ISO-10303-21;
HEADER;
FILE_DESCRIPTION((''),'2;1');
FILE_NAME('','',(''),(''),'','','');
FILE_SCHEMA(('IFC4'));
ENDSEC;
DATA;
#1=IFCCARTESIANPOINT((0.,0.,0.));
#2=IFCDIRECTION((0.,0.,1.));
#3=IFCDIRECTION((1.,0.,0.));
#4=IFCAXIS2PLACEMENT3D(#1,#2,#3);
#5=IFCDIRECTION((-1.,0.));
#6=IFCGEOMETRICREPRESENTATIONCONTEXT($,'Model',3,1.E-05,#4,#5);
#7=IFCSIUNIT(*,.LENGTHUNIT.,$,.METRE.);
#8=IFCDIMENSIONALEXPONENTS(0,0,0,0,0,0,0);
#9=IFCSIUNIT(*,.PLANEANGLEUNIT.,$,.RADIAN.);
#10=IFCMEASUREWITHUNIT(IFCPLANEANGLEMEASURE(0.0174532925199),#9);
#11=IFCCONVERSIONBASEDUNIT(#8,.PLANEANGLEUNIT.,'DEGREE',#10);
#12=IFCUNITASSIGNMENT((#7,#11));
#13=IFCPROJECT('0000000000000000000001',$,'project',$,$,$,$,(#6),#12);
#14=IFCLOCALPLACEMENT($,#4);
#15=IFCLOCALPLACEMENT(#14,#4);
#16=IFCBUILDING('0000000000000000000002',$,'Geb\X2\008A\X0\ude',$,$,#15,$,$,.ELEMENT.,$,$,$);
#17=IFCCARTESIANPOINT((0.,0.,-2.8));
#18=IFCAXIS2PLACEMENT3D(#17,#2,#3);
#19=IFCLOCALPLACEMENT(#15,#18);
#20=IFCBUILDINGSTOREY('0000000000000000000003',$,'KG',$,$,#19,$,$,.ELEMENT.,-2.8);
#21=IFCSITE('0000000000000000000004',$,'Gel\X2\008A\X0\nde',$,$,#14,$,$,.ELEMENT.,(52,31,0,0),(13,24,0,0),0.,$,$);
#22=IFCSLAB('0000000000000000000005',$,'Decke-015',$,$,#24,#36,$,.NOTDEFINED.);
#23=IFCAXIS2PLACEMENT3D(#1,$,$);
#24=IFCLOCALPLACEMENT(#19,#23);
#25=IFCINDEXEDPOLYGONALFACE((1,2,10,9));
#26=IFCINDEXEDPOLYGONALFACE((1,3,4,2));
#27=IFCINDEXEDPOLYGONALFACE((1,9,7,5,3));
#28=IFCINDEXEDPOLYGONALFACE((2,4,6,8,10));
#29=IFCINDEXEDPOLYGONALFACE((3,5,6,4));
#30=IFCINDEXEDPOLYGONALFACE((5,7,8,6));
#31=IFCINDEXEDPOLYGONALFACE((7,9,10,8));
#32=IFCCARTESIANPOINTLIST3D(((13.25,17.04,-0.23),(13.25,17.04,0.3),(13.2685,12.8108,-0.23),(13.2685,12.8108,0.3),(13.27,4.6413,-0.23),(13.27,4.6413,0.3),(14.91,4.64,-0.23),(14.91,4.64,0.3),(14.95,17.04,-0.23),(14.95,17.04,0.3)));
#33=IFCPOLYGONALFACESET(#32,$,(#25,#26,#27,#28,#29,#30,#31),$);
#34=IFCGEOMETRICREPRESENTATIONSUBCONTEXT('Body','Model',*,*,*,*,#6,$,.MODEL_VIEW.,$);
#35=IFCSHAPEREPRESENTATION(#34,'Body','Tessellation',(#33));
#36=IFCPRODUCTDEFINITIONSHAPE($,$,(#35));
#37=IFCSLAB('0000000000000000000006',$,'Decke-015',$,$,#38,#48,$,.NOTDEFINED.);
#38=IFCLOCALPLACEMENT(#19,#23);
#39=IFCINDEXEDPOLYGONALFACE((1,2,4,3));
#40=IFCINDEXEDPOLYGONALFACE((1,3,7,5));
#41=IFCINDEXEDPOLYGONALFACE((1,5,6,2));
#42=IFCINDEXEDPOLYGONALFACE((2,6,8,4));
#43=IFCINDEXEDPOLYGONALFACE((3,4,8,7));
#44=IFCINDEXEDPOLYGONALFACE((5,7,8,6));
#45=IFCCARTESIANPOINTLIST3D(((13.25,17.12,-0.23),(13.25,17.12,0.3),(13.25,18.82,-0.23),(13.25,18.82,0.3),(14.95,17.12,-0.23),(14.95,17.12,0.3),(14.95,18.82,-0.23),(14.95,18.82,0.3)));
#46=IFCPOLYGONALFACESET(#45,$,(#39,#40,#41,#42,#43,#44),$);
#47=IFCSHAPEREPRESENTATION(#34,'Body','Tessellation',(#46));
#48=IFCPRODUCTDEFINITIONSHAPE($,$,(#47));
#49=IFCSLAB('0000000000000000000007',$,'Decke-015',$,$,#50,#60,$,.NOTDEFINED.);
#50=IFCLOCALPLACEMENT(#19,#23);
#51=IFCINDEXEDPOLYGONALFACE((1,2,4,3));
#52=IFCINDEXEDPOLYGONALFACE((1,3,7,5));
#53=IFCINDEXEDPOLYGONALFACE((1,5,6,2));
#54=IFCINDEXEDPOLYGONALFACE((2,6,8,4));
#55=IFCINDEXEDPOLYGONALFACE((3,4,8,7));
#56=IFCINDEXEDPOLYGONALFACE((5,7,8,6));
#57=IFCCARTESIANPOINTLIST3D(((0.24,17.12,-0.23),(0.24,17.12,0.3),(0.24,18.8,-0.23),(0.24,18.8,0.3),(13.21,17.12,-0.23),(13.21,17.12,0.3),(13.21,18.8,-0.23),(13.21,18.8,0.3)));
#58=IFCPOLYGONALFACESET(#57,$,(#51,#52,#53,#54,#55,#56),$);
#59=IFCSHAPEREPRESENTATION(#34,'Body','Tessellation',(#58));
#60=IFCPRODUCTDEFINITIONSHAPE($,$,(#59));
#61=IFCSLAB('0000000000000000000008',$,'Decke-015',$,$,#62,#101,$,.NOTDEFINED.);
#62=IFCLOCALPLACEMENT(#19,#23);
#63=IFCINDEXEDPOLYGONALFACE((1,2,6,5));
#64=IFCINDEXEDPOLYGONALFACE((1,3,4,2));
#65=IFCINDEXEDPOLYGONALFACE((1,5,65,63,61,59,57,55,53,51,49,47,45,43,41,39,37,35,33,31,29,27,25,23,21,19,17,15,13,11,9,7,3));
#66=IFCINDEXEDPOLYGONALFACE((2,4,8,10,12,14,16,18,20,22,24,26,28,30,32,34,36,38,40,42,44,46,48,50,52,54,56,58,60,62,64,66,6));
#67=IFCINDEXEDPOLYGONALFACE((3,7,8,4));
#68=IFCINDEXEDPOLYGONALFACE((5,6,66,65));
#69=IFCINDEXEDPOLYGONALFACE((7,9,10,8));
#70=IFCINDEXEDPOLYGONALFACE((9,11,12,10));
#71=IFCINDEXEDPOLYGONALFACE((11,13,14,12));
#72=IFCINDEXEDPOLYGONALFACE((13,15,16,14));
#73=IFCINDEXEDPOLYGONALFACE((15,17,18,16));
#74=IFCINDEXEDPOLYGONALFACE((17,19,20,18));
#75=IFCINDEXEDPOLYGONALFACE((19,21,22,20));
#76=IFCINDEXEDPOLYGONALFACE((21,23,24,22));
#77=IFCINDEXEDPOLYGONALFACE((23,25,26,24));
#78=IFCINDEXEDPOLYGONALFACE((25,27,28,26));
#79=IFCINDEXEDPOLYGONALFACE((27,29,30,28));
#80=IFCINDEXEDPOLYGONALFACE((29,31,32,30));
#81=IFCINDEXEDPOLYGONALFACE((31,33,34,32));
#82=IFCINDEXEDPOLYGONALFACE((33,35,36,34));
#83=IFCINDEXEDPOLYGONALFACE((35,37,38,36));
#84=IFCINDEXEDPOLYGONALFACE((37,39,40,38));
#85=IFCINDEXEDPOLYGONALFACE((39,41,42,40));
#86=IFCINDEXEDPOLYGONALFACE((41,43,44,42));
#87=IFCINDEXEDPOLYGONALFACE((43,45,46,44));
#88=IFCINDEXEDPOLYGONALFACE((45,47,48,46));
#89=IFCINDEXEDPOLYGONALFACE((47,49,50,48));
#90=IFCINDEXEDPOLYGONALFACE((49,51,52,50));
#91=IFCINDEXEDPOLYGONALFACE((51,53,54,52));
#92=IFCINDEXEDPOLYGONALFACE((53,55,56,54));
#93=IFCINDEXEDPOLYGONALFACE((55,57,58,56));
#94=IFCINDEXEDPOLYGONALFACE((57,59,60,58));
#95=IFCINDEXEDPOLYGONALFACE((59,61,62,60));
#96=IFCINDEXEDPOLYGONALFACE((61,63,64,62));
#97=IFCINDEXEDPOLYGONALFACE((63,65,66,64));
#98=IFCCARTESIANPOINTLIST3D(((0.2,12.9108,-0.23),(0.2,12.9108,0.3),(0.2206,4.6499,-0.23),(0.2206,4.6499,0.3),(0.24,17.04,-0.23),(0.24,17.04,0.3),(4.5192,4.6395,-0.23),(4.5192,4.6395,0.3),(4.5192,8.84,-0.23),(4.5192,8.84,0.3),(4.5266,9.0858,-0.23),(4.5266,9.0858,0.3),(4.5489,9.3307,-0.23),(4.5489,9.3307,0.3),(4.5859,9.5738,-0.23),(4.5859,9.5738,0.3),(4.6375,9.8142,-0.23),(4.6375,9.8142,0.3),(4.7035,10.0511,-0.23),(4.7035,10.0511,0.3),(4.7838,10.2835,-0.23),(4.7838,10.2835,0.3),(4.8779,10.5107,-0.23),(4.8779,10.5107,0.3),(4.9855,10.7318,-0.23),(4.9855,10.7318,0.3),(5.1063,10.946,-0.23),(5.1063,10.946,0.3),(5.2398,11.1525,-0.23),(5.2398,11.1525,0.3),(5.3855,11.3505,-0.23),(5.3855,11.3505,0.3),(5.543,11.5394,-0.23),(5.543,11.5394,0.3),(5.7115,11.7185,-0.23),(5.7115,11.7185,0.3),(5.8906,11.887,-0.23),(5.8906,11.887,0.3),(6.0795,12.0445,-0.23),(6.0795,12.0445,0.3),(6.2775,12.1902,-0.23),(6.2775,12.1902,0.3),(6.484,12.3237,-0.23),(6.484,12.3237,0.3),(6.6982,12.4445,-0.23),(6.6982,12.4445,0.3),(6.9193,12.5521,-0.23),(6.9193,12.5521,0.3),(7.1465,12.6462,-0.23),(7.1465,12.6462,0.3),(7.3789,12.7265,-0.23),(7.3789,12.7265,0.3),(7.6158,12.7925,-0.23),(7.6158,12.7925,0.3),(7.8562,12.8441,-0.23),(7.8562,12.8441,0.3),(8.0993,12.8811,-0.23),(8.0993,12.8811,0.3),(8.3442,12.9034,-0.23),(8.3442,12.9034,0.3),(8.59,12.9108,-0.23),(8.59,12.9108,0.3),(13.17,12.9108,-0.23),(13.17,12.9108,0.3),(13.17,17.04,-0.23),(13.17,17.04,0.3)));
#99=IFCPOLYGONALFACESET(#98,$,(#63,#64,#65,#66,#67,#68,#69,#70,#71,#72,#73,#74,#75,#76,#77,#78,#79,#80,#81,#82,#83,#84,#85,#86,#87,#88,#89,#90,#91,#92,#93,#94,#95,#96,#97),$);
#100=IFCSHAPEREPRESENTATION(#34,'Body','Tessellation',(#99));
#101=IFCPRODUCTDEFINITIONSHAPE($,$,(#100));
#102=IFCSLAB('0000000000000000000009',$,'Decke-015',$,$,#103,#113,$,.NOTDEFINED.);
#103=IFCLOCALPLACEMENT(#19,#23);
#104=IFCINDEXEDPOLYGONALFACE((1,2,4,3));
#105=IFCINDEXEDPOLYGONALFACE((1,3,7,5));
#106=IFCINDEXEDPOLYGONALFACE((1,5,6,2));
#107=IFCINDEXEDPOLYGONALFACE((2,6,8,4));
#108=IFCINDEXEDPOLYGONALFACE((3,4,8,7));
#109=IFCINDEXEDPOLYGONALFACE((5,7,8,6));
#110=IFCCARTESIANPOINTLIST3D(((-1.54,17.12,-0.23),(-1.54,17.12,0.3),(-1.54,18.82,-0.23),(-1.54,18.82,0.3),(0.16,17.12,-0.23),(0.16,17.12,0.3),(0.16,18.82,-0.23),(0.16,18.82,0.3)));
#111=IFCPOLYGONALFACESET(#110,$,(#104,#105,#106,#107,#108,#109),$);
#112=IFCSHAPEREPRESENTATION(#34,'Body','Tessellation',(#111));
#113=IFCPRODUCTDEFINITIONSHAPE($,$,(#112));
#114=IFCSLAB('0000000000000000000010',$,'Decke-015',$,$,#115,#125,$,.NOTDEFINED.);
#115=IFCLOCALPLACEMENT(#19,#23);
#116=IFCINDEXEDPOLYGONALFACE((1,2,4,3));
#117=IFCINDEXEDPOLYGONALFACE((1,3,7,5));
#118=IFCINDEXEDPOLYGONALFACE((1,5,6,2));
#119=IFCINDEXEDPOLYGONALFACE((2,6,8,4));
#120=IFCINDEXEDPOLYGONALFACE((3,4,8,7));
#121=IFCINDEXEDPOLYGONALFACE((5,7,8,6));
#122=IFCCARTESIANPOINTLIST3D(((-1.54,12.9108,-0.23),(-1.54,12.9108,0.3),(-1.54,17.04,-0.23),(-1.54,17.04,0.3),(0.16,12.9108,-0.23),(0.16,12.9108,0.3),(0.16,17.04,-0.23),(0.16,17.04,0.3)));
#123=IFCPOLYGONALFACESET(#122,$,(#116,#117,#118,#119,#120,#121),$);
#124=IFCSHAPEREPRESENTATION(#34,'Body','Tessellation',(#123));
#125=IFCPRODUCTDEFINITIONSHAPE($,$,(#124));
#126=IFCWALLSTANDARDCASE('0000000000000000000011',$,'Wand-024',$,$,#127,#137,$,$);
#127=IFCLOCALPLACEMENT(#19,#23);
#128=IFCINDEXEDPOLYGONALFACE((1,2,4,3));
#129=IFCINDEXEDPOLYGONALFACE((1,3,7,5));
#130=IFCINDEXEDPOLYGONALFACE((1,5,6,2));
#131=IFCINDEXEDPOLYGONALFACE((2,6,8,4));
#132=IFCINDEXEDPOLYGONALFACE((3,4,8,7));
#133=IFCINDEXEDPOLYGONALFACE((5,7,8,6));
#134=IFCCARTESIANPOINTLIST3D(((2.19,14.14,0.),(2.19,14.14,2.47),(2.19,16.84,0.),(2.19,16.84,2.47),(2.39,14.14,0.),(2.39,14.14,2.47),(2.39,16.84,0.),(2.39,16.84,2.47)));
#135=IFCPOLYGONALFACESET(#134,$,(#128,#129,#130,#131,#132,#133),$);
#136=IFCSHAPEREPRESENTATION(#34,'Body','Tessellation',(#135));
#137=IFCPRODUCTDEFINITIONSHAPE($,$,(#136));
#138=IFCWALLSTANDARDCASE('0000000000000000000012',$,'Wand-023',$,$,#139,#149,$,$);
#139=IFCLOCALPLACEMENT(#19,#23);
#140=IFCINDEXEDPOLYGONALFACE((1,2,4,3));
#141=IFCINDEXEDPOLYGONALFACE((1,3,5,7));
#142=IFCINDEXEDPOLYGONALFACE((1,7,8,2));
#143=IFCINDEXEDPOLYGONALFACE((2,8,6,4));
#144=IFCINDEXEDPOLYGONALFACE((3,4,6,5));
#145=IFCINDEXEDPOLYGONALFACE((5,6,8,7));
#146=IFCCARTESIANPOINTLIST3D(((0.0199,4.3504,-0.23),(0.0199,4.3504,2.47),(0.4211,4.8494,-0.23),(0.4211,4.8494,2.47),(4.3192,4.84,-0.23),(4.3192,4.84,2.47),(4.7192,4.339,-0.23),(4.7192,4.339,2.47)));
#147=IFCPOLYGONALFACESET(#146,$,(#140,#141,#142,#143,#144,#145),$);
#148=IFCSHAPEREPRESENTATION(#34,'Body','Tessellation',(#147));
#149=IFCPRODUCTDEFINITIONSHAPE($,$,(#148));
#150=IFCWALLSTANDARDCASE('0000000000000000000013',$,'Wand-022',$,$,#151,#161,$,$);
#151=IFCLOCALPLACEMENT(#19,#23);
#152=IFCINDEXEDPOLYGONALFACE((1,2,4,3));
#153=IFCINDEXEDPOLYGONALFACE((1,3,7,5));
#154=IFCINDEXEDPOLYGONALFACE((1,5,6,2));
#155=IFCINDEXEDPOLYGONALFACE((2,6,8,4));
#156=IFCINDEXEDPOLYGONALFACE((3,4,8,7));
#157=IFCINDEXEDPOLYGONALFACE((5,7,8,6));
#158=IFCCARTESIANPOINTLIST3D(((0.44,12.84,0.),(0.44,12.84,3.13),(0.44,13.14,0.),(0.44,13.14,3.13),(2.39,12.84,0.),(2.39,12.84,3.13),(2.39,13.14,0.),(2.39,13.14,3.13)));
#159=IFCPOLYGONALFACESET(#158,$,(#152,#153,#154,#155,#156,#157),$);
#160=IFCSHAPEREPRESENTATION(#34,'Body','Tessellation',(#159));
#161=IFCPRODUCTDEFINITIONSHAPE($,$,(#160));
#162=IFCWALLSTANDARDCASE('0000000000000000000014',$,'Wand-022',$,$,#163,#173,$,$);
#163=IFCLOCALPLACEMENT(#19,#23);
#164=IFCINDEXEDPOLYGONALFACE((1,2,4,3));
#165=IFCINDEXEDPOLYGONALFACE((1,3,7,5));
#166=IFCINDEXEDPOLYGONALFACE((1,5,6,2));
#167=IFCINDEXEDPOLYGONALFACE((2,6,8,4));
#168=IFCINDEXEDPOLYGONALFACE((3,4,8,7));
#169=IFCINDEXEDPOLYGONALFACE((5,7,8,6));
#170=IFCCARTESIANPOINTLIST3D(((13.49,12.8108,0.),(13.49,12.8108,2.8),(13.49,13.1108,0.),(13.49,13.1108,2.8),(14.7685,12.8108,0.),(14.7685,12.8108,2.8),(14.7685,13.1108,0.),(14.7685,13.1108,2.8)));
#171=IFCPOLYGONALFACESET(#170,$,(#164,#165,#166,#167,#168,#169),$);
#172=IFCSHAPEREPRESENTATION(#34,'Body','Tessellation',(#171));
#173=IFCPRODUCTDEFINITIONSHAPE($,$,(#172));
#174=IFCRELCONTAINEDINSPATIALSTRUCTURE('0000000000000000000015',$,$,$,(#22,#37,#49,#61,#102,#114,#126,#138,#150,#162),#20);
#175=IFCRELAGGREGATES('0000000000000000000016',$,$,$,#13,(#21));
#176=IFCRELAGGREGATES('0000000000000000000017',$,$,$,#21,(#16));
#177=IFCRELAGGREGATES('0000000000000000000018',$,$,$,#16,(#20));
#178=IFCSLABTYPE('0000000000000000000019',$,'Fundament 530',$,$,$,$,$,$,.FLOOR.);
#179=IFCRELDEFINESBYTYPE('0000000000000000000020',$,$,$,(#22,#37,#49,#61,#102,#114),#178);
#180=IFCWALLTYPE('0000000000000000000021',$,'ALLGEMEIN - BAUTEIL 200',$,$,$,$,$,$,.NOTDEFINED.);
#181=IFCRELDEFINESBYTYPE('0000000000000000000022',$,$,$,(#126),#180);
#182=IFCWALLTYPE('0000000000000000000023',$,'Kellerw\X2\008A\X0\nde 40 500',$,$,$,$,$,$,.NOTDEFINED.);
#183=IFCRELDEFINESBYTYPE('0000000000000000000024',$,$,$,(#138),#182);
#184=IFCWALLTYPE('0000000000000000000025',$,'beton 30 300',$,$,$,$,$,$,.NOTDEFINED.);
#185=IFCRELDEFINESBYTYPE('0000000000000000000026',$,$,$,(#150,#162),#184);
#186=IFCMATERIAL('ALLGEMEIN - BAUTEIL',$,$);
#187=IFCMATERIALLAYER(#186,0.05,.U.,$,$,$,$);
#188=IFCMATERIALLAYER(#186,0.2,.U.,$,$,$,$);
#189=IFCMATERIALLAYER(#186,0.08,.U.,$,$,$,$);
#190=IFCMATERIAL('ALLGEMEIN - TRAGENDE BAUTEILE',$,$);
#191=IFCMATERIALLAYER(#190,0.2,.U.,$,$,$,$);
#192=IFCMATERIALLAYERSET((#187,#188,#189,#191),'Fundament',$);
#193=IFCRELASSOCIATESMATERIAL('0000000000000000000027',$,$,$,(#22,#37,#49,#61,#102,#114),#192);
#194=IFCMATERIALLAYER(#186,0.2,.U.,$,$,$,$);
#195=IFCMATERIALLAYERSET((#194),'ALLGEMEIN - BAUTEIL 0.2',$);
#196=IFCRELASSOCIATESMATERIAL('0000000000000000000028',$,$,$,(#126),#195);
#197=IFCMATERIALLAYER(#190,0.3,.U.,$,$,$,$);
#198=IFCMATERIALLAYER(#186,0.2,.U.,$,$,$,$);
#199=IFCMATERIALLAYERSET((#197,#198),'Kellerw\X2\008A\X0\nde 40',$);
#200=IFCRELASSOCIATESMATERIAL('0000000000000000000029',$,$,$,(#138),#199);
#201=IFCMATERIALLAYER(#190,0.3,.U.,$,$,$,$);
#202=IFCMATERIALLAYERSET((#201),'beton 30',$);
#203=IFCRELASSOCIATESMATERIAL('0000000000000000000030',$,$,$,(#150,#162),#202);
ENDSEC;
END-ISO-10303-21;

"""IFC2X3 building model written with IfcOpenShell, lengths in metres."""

from ifc_helpers import new_model, entity, si_unit, converted_unit, point, direction, frame, frame_2d, origin_with_axes, place, context, subcontext, project, spatial, polyline, circle_curve, parameter, trimmed, segment, composite_curve, outline, extrude, material, layer, layer_set, layer_usage, type_object, element, save


model = new_model("IFC2X3")

# Units and contexts
model_context = context("Model", 3, precision=1e-05, world=origin_with_axes(), true_north=direction((-1.0, 0.0)))
body_context = subcontext(model_context, "Body", "Model", "MODEL_VIEW")
ifc_project = project(units=[si_unit("LENGTHUNIT", "METRE"), converted_unit("PLANEANGLEUNIT", "DEGREE", entity("IfcPlaneAngleMeasure", 0.0174532925199), si_unit("PLANEANGLEUNIT", "RADIAN"), dimensions=[0, 0, 0, 0, 0, 0, 0])], contexts=[model_context])

# Site, building, storey
site_placement = place(None, origin_with_axes())
site = spatial("IfcSite", under=ifc_project, at=site_placement, Name="Gel\u008ande", CompositionType="ELEMENT", RefLatitude=(52, 31, 0, 0), RefLongitude=(13, 24, 0, 0), RefElevation=0.0)
building_placement = place(site_placement, origin_with_axes())
building = spatial("IfcBuilding", under=site, at=building_placement, Name="Geb\u008aude", CompositionType="ELEMENT")
storey_placement = place(building_placement, frame((0.0, 0.0, -2.8), z_axis=(0.0, 0.0, 1.0), x_axis=(1.0, 0.0, 0.0)))
storey = spatial("IfcBuildingStorey", under=building, at=storey_placement, Name="KG", CompositionType="ELEMENT", Elevation=-2.8)

# Slabs
ifc_material_1 = material(Name="ALLGEMEIN - BAUTEIL")
ifc_layer_1 = layer(ifc_material_1, 0.05, ventilated="UNKNOWN")
ifc_layer_2 = layer(ifc_material_1, 0.2, ventilated="UNKNOWN")
ifc_layer_3 = layer(ifc_material_1, 0.08, ventilated="UNKNOWN")
ifc_material_2 = material(Name="ALLGEMEIN - TRAGENDE BAUTEILE")
ifc_layer_4 = layer(ifc_material_2, 0.2, ventilated="UNKNOWN")
ifc_layer_set_1 = layer_set([ifc_layer_1, ifc_layer_2, ifc_layer_3, ifc_layer_4], Name="Fundament")
ifc_layer_usage_1 = layer_usage(ifc_layer_set_1, "AXIS3", "NEGATIVE", 0.53)
slab_type = type_object("IfcSlabType", Name="Fundament 530", PredefinedType="FLOOR")
slab_1_placement = place(storey_placement, frame((13.25, 17.04, 0.3), z_axis=(0.0, 0.0, 1.0), x_axis=(1.0, 0.0, 0.0)))
element("IfcSlab", 1, at=slab_1_placement, inside=storey, type_object=slab_type, material=ifc_layer_usage_1, Name="Decke-015", PredefinedType="NOTDEFINED", context=body_context, shape_type="SweptSolid", body=[
    extrude(outline(polyline([(0.0, 0.0), (0.0185, -4.2292), (0.02, -12.3987), (1.66, -12.4), (1.7, 0.0), (0.0, 0.0)])), frame((0.0, 0.0, -0.53), z_axis=(0.0, 0.0, 1.0), x_axis=(1.0, 0.0, 0.0)), (0.0, 0.0, 1.0), 0.53),
])
ifc_layer_usage_2 = layer_usage(ifc_layer_set_1, "AXIS3", "NEGATIVE", 0.53)
slab_2_placement = place(storey_placement, frame((14.95, 18.82, 0.3), z_axis=(0.0, 0.0, 1.0), x_axis=(1.0, 0.0, 0.0)))
element("IfcSlab", 2, at=slab_2_placement, inside=storey, type_object=slab_type, material=ifc_layer_usage_2, Name="Decke-015", PredefinedType="NOTDEFINED", context=body_context, shape_type="SweptSolid", body=[
    extrude(outline(polyline([(0.0, 0.0), (-1.7, 0.0), (-1.7, -1.7), (0.0, -1.7), (0.0, 0.0)])), frame((0.0, 0.0, -0.53), z_axis=(0.0, 0.0, 1.0), x_axis=(1.0, 0.0, 0.0)), (0.0, 0.0, 1.0), 0.53),
])
ifc_layer_usage_3 = layer_usage(ifc_layer_set_1, "AXIS3", "NEGATIVE", 0.53)
slab_3_placement = place(storey_placement, frame((0.24, 18.8, 0.3), z_axis=(0.0, 0.0, 1.0), x_axis=(1.0, 0.0, 0.0)))
element("IfcSlab", 3, at=slab_3_placement, inside=storey, type_object=slab_type, material=ifc_layer_usage_3, Name="Decke-015", PredefinedType="NOTDEFINED", context=body_context, shape_type="SweptSolid", body=[
    extrude(outline(polyline([(0.0, 0.0), (0.0, -1.68), (12.97, -1.68), (12.97, 0.0), (0.0, 0.0)])), frame((0.0, 0.0, -0.53), z_axis=(0.0, 0.0, 1.0), x_axis=(1.0, 0.0, 0.0)), (0.0, 0.0, 1.0), 0.53),
])
ifc_layer_usage_4 = layer_usage(ifc_layer_set_1, "AXIS3", "NEGATIVE", 0.53)
slab_4_placement = place(storey_placement, frame((0.24, 17.04, 0.3), z_axis=(0.0, 0.0, 1.0), x_axis=(1.0, 0.0, 0.0)))
element("IfcSlab", 4, at=slab_4_placement, inside=storey, type_object=slab_type, material=ifc_layer_usage_4, Name="Decke-015", PredefinedType="NOTDEFINED", context=body_context, shape_type="SweptSolid", body=[
    extrude(outline(composite_curve([segment(trimmed(circle_curve(frame_2d((8.35, -8.2), x_axis=(0.0, 1.0)), 4.0708), [point((4.2792, -8.2)), parameter(90.0)], [point((8.35, -4.1292)), parameter(0.0)], False, "CARTESIAN"), True, "CONTINUOUS"), segment(polyline([(8.35, -4.1292), (12.93, -4.1292), (12.93, 0.0), (0.0, 0.0)]), True, "CONTINUOUS"), segment(polyline([(0.0, 0.0), (-0.04, -4.1292), (-0.0194, -12.3901), (4.2792, -12.4005), (4.2792, -8.2)]), True, "CONTINUOUS")], self_intersect=False)), frame((0.0, 0.0, -0.53), z_axis=(0.0, 0.0, 1.0), x_axis=(1.0, 0.0, 0.0)), (0.0, 0.0, 1.0), 0.53),
])
ifc_layer_usage_5 = layer_usage(ifc_layer_set_1, "AXIS3", "NEGATIVE", 0.53)
slab_5_placement = place(storey_placement, frame((0.16, 18.82, 0.3), z_axis=(0.0, 0.0, 1.0), x_axis=(1.0, 0.0, 0.0)))
element("IfcSlab", 5, at=slab_5_placement, inside=storey, type_object=slab_type, material=ifc_layer_usage_5, Name="Decke-015", PredefinedType="NOTDEFINED", context=body_context, shape_type="SweptSolid", body=[
    extrude(outline(polyline([(0.0, 0.0), (-1.7, 0.0), (-1.7, -1.7), (0.0, -1.7), (0.0, 0.0)])), frame((0.0, 0.0, -0.53), z_axis=(0.0, 0.0, 1.0), x_axis=(1.0, 0.0, 0.0)), (0.0, 0.0, 1.0), 0.53),
])
ifc_layer_usage_6 = layer_usage(ifc_layer_set_1, "AXIS3", "NEGATIVE", 0.53)
slab_6_placement = place(storey_placement, frame((0.16, 17.04, 0.3), z_axis=(0.0, 0.0, 1.0), x_axis=(1.0, 0.0, 0.0)))
element("IfcSlab", 6, at=slab_6_placement, inside=storey, type_object=slab_type, material=ifc_layer_usage_6, Name="Decke-015", PredefinedType="NOTDEFINED", context=body_context, shape_type="SweptSolid", body=[
    extrude(outline(polyline([(0.0, 0.0), (-1.7, 0.0), (-1.7, -4.1292), (0.0, -4.1292), (0.0, 0.0)])), frame((0.0, 0.0, -0.53), z_axis=(0.0, 0.0, 1.0), x_axis=(1.0, 0.0, 0.0)), (0.0, 0.0, 1.0), 0.53),
])

# Walls
ifc_layer_5 = layer(ifc_material_1, 0.2, ventilated="UNKNOWN")
ifc_layer_set_2 = layer_set([ifc_layer_5], Name="ALLGEMEIN - BAUTEIL 0.2")
ifc_layer_usage_7 = layer_usage(ifc_layer_set_2, "AXIS2", "POSITIVE", 0.0)
wall_type_1 = type_object("IfcWallType", Name="ALLGEMEIN - BAUTEIL 200", PredefinedType="NOTDEFINED")
wall_1_placement = place(storey_placement, frame((2.19, 16.84, 0.0), z_axis=(0.0, 0.0, 1.0), x_axis=(0.0, -1.0, 0.0)))
element("IfcWallStandardCase", 7, at=wall_1_placement, inside=storey, type_object=wall_type_1, material=ifc_layer_usage_7, Name="Wand-024", context=body_context, shape_type="SweptSolid", body=[
    extrude(outline(polyline([(0.0, 0.0), (2.7, 0.0), (2.7, 0.2), (0.0, 0.2), (0.0, 0.0)])), origin_with_axes(), (0.0, 0.0, 1.0), 2.47),
])
ifc_layer_6 = layer(ifc_material_2, 0.3, ventilated="UNKNOWN")
ifc_layer_7 = layer(ifc_material_1, 0.2, ventilated="UNKNOWN")
ifc_layer_set_3 = layer_set([ifc_layer_6, ifc_layer_7], Name="Kellerw\u008ande 40")
ifc_layer_usage_8 = layer_usage(ifc_layer_set_3, "AXIS2", "NEGATIVE", 0.0)
wall_type_2 = type_object("IfcWallType", Name="Kellerw\u008ande 40 500", PredefinedType="NOTDEFINED")
wall_2_placement = place(storey_placement, frame((0.4211, 4.8494, -0.23), z_axis=(0.0, 0.0, 1.0), x_axis=(0.999997, -0.002408, 0.0)))
element("IfcWallStandardCase", 8, at=wall_2_placement, inside=storey, type_object=wall_type_2, material=ifc_layer_usage_8, Name="Wand-023", context=body_context, shape_type="SweptSolid", body=[
    extrude(outline(polyline([(-0.4, -0.5), (4.2994, -0.5), (3.8981, 0.0), (0.0, 0.0), (-0.4, -0.5)])), origin_with_axes(), (0.0, 0.0, 1.0), 2.7),
])
ifc_layer_8 = layer(ifc_material_2, 0.3, ventilated="UNKNOWN")
ifc_layer_set_4 = layer_set([ifc_layer_8], Name="beton 30")
ifc_layer_usage_9 = layer_usage(ifc_layer_set_4, "AXIS2", "POSITIVE", 0.0)
wall_type_3 = type_object("IfcWallType", Name="beton 30 300", PredefinedType="NOTDEFINED")
wall_3_placement = place(storey_placement, frame((0.44, 12.84, 0.0), z_axis=(0.0, 0.0, 1.0), x_axis=(1.0, 0.0, 0.0)))
element("IfcWallStandardCase", 9, at=wall_3_placement, inside=storey, type_object=wall_type_3, material=ifc_layer_usage_9, Name="Wand-022", context=body_context, shape_type="SweptSolid", body=[
    extrude(outline(polyline([(0.0, 0.0), (1.95, 0.0), (1.95, 0.3), (0.0, 0.3), (0.0, 0.0)])), origin_with_axes(), (0.0, 0.0, 1.0), 3.13),
])
ifc_layer_usage_10 = layer_usage(ifc_layer_set_4, "AXIS2", "POSITIVE", 0.0)
wall_4_placement = place(storey_placement, frame((13.49, 12.8108, 0.0), z_axis=(0.0, 0.0, 1.0), x_axis=(1.0, 0.0, 0.0)))
element("IfcWallStandardCase", 10, at=wall_4_placement, inside=storey, type_object=wall_type_3, material=ifc_layer_usage_10, Name="Wand-022", context=body_context, shape_type="SweptSolid", body=[
    extrude(outline(polyline([(0.0, 0.0), (1.2785, 0.0), (1.2785, 0.3), (0.0, 0.3), (0.0, 0.0)])), origin_with_axes(), (0.0, 0.0, 1.0), 2.8),
])

save(model, "model.ifc")
